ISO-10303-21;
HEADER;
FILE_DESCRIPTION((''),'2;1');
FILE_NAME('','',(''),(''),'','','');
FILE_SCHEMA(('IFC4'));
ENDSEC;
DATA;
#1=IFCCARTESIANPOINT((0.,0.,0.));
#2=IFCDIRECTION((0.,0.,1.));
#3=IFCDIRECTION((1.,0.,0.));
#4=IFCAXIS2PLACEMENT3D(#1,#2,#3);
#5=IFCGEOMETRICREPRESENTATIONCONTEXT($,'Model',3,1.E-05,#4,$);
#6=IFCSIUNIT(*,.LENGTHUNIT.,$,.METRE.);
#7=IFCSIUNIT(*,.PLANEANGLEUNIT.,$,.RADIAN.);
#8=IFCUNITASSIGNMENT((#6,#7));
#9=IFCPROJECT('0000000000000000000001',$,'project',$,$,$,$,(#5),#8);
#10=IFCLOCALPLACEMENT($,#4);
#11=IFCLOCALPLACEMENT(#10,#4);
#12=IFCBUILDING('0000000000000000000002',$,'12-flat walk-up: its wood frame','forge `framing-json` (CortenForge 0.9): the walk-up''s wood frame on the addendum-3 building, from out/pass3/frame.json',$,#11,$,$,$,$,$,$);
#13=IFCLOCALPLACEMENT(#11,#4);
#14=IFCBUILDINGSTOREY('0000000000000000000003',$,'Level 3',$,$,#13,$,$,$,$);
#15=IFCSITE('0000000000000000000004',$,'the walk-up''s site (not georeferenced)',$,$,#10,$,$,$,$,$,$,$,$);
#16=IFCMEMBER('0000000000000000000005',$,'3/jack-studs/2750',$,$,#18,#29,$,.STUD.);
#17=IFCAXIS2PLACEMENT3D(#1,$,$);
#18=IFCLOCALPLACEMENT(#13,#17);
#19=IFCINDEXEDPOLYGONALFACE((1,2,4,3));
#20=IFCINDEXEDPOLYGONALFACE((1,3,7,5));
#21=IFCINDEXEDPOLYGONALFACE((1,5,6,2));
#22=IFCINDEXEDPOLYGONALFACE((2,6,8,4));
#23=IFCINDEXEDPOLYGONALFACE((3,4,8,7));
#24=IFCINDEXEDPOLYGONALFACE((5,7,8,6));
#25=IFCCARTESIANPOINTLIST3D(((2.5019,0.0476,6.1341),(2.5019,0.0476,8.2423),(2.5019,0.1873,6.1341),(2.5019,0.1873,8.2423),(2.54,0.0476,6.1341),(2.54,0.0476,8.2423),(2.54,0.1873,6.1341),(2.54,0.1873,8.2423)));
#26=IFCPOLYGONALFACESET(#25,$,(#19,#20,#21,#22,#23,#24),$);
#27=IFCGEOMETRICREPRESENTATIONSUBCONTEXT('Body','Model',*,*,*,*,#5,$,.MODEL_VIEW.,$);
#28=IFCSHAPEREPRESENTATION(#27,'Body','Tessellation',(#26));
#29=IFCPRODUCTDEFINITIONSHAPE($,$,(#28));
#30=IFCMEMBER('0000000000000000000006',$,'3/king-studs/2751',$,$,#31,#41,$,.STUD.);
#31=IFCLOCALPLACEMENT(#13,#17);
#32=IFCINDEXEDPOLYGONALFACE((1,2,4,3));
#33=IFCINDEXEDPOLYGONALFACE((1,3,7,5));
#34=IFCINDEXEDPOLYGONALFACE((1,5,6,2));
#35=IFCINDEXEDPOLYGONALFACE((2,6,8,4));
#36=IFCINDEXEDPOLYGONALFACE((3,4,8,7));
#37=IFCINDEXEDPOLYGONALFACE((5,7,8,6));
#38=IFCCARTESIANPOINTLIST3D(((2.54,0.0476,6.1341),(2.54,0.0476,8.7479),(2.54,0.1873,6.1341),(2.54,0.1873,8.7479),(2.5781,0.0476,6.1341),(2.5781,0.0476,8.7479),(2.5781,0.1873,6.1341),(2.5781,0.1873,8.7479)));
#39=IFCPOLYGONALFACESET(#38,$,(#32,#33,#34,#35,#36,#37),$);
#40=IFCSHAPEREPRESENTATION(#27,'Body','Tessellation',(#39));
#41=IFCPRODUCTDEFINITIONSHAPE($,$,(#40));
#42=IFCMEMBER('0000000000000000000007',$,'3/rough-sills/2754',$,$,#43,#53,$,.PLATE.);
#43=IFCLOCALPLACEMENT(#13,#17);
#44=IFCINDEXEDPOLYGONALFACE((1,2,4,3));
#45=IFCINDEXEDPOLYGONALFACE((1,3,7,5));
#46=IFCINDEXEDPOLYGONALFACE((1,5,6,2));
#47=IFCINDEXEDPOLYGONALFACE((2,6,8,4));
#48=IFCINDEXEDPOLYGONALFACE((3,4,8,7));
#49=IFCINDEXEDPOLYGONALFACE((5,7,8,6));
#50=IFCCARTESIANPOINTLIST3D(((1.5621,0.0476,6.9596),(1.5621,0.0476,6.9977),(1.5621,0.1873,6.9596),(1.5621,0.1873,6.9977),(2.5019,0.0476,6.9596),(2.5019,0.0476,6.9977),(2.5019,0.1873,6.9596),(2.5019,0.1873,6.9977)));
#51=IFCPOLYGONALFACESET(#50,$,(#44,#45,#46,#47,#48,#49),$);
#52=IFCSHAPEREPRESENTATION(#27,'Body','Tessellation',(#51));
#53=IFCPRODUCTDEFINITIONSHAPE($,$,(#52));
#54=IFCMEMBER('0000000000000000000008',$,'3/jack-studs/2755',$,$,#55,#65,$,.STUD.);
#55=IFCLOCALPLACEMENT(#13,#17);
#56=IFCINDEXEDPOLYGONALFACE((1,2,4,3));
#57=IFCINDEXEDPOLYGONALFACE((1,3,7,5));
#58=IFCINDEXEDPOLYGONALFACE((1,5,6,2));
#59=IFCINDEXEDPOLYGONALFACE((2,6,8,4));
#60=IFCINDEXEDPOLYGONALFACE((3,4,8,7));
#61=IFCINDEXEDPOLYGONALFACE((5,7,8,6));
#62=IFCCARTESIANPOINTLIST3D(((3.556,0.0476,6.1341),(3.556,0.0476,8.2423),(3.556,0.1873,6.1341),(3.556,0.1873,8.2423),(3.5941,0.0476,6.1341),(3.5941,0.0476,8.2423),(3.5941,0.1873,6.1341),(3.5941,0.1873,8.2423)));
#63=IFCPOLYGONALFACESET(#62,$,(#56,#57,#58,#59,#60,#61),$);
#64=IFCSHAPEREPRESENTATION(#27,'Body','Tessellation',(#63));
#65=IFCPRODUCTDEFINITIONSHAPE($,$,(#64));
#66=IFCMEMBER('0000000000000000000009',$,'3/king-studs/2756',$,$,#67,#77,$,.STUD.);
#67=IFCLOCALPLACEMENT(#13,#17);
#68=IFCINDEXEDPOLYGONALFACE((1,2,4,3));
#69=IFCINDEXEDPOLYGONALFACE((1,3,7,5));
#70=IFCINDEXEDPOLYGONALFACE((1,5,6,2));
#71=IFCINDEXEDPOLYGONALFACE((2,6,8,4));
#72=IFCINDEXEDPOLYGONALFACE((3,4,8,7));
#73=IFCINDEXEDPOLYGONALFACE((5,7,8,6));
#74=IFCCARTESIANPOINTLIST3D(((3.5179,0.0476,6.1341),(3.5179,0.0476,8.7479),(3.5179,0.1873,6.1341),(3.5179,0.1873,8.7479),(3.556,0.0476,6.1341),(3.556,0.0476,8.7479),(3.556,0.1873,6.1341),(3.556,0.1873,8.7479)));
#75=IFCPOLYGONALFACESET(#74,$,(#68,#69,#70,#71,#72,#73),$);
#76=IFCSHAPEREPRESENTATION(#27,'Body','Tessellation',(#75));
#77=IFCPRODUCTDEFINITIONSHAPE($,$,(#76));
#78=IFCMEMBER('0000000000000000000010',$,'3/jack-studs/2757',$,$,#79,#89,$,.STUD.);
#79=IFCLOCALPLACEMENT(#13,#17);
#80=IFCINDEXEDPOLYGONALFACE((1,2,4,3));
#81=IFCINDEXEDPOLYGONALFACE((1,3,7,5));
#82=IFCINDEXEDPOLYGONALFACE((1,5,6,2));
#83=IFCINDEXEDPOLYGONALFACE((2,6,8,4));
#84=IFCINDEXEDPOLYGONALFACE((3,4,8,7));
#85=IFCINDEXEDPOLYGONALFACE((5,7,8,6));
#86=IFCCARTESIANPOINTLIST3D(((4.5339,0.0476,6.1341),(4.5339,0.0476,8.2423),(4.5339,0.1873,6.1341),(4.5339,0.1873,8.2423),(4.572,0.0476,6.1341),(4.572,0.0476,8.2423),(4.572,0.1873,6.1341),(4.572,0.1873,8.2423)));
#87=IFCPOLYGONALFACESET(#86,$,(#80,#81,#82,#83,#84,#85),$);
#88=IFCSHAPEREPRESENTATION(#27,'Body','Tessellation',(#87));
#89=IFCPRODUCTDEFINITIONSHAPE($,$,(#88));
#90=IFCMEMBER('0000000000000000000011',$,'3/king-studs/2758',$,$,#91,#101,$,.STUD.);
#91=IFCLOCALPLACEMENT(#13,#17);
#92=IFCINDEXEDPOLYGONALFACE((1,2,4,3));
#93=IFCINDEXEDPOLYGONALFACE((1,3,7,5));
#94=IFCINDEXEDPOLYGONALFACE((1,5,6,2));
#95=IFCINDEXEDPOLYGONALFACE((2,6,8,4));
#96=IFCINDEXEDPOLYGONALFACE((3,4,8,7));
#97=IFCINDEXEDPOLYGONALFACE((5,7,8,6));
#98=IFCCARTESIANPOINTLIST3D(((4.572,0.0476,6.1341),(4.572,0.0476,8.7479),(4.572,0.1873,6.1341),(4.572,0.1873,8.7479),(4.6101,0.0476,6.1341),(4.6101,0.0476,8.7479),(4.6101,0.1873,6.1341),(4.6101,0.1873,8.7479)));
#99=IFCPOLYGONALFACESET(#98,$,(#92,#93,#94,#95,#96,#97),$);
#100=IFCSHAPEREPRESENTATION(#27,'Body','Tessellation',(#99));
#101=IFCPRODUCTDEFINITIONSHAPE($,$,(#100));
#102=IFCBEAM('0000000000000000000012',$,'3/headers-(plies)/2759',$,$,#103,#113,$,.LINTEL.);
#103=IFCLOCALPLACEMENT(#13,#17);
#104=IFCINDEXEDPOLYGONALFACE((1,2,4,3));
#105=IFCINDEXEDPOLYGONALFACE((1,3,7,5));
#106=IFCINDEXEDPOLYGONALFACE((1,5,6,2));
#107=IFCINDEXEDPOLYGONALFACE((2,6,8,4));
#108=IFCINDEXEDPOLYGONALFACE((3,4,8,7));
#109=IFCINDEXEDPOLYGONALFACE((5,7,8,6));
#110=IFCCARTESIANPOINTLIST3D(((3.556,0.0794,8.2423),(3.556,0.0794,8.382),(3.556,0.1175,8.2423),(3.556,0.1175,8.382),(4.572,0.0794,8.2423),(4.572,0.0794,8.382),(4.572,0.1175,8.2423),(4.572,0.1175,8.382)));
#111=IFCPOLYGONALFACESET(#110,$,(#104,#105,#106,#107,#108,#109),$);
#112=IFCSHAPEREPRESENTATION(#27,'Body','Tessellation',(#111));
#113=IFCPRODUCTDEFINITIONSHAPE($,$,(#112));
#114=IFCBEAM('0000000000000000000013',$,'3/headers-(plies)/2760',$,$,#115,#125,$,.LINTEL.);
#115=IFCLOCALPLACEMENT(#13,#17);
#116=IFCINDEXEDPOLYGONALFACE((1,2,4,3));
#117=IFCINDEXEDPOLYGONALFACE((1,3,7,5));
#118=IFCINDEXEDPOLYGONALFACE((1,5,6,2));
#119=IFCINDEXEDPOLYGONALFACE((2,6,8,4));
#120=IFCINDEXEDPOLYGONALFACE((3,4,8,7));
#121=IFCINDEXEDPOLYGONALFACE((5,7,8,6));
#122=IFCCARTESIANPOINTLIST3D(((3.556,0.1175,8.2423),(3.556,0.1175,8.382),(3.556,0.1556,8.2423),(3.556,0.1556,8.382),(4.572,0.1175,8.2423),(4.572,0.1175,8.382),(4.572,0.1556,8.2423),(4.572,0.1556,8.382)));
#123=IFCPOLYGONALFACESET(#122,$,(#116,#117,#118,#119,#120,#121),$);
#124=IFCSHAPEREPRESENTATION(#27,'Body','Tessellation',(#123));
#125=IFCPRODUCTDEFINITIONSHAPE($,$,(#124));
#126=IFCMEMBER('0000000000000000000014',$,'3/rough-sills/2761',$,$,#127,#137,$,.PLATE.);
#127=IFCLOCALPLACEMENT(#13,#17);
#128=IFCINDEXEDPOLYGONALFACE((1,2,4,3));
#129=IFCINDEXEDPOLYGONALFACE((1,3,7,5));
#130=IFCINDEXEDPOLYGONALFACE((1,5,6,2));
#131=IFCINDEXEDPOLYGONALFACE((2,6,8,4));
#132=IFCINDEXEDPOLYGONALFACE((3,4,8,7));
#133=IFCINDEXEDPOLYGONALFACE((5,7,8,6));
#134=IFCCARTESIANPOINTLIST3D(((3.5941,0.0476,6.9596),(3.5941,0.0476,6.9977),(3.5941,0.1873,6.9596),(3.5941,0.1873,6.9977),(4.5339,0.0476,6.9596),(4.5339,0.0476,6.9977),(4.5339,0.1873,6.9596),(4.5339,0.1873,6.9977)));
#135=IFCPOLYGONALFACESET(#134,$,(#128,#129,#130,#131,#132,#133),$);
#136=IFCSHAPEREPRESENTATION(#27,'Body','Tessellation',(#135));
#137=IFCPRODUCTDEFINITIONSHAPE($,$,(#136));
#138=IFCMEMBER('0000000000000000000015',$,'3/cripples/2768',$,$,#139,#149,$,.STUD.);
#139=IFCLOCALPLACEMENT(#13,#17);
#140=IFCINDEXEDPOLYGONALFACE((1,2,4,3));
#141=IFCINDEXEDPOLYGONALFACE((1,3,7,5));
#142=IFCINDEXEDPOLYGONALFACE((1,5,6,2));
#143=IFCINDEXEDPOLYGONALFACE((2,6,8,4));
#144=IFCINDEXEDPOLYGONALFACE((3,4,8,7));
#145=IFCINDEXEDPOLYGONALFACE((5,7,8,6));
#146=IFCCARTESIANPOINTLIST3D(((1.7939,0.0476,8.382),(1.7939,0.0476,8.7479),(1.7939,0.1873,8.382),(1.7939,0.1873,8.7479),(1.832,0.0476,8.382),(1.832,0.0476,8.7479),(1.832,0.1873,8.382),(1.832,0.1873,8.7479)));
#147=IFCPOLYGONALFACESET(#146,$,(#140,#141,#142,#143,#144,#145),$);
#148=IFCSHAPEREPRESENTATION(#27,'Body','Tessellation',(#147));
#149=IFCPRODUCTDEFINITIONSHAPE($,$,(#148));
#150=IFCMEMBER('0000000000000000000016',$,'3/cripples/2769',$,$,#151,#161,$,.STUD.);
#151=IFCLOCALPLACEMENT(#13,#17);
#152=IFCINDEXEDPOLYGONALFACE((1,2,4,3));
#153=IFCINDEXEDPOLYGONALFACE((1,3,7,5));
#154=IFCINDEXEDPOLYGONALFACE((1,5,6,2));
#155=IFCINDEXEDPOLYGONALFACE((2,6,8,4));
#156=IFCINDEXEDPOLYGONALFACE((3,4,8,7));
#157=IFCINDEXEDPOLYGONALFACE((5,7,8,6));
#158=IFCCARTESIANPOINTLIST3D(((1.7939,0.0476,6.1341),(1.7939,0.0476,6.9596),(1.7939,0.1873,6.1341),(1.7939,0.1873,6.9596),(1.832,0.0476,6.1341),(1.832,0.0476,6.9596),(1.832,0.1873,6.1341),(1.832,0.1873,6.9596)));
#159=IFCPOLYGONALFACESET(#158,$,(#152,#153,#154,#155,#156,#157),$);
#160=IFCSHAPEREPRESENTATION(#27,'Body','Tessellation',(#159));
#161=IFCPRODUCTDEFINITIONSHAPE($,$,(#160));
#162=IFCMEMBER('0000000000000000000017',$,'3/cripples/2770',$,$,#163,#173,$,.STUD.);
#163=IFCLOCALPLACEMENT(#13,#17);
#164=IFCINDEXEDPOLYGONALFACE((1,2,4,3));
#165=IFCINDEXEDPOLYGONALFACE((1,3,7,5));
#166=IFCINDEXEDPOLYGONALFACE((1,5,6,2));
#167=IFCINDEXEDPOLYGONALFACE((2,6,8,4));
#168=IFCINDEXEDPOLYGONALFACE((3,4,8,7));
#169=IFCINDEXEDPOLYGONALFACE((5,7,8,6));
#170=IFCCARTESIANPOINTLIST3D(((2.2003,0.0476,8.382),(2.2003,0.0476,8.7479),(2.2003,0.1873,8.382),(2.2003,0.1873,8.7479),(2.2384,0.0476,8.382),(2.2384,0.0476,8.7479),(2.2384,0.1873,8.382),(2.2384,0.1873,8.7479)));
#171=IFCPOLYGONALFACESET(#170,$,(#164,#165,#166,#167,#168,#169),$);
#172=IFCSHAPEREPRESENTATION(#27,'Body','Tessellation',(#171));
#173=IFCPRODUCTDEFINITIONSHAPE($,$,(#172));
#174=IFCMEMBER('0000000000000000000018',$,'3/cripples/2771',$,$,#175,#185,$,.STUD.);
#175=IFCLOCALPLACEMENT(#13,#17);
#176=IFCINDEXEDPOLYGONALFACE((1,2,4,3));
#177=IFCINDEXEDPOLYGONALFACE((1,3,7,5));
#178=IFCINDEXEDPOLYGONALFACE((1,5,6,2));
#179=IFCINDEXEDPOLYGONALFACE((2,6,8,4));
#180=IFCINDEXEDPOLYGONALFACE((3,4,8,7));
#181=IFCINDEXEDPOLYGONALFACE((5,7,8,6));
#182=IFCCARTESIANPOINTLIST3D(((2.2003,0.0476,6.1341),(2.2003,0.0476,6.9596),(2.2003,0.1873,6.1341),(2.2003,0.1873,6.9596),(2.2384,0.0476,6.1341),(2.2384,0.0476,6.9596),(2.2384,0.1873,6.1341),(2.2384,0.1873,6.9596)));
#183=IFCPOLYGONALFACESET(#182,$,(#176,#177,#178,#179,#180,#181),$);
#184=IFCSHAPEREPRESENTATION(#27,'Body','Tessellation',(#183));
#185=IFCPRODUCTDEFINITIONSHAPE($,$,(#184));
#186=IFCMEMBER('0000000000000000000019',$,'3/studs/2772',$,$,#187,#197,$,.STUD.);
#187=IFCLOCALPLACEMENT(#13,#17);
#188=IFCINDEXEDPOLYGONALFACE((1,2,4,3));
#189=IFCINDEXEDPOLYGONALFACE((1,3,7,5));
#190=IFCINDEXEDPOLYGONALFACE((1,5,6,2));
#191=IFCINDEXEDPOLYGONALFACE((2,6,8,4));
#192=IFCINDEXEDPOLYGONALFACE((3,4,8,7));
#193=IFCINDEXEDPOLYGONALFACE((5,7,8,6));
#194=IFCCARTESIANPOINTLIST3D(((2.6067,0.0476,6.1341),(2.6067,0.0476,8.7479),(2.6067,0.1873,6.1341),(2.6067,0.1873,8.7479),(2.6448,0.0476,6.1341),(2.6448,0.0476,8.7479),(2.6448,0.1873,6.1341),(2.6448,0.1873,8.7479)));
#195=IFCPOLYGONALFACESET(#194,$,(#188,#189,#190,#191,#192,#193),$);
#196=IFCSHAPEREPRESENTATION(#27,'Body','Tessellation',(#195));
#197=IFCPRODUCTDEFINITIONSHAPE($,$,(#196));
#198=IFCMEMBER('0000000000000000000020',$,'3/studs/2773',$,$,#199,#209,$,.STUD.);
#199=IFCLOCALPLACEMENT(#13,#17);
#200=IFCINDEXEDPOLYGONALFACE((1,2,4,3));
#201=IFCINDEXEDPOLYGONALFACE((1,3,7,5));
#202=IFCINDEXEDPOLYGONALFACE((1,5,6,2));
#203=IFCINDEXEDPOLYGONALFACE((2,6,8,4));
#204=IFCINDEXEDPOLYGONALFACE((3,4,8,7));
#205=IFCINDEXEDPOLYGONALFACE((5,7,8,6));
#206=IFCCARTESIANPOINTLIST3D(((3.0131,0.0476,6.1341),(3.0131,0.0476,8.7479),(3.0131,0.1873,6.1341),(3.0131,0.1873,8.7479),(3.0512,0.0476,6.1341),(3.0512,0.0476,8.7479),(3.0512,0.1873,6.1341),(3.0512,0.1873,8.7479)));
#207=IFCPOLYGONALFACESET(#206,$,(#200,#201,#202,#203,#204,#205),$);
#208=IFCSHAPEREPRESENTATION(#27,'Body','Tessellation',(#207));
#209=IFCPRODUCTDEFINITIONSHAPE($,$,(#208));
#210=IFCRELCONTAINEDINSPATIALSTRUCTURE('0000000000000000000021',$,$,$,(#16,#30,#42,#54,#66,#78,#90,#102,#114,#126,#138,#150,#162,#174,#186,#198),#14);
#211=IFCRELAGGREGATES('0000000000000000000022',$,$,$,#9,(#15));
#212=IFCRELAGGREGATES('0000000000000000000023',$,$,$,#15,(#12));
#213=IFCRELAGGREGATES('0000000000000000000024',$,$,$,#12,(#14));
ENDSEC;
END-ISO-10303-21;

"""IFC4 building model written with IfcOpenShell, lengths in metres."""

from ifc_helpers import new_model, si_unit, frame, frame_2d, origin, origin_with_axes, place, context, subcontext, project, spatial, rectangle, extrude, element, save


model = new_model("IFC4")

# Units and contexts
model_context = context("Model", 3, precision=1e-05, world=origin_with_axes())
body_context = subcontext(model_context, "Body", "Model", "MODEL_VIEW")
ifc_project = project(units=[si_unit("LENGTHUNIT", "METRE"), si_unit("PLANEANGLEUNIT", "RADIAN")], contexts=[model_context])

# Site, building, storey
site_placement = place(None, origin_with_axes())
site = spatial("IfcSite", under=ifc_project, at=site_placement, Name="the walk-up's site (not georeferenced)")
building_placement = place(site_placement, origin_with_axes())
building = spatial("IfcBuilding", under=site, at=building_placement, Name="12-flat walk-up: its wood frame", Description="forge `framing-json` (CortenForge 0.9): the walk-up's wood frame on the addendum-3 building, from out/pass3/frame.json")
storey_placement = place(building_placement, origin_with_axes())
storey = spatial("IfcBuildingStorey", under=building, at=storey_placement, Name="Level 3")

# Members
member_1_placement = place(storey_placement, frame((2.5019, 0.0476, 6.1341), z_axis=(0.0, 0.0, 1.0), x_axis=(1.0, 0.0, 0.0)))
element("IfcMember", 1, at=member_1_placement, inside=storey, Name="3/jack-studs/2750", PredefinedType="STUD", context=body_context, shape_type="SweptSolid", body=[
    extrude(rectangle(XDim=0.0381, YDim=0.1397, at=frame_2d((0.0191, 0.0698))), origin(), (0.0, 0.0, 1.0), 2.1082),
])
member_2_placement = place(storey_placement, frame((2.54, 0.0476, 6.1341), z_axis=(0.0, 0.0, 1.0), x_axis=(1.0, 0.0, 0.0)))
element("IfcMember", 2, at=member_2_placement, inside=storey, Name="3/king-studs/2751", PredefinedType="STUD", context=body_context, shape_type="SweptSolid", body=[
    extrude(rectangle(XDim=0.0381, YDim=0.1397, at=frame_2d((0.0191, 0.0698))), origin(), (0.0, 0.0, 1.0), 2.6138),
])
member_3_placement = place(storey_placement, frame((1.5621, 0.0476, 6.9596), z_axis=(0.0, 0.0, 1.0), x_axis=(1.0, 0.0, 0.0)))
element("IfcMember", 3, at=member_3_placement, inside=storey, Name="3/rough-sills/2754", PredefinedType="PLATE", context=body_context, shape_type="SweptSolid", body=[
    extrude(rectangle(XDim=0.9398, YDim=0.1397, at=frame_2d((0.4699, 0.0698))), origin(), (0.0, 0.0, 1.0), 0.0381),
])
member_4_placement = place(storey_placement, frame((3.556, 0.0476, 6.1341), z_axis=(0.0, 0.0, 1.0), x_axis=(1.0, 0.0, 0.0)))
element("IfcMember", 4, at=member_4_placement, inside=storey, Name="3/jack-studs/2755", PredefinedType="STUD", context=body_context, shape_type="SweptSolid", body=[
    extrude(rectangle(XDim=0.0381, YDim=0.1397, at=frame_2d((0.0191, 0.0698))), origin(), (0.0, 0.0, 1.0), 2.1082),
])
member_5_placement = place(storey_placement, frame((3.5179, 0.0476, 6.1341), z_axis=(0.0, 0.0, 1.0), x_axis=(1.0, 0.0, 0.0)))
element("IfcMember", 5, at=member_5_placement, inside=storey, Name="3/king-studs/2756", PredefinedType="STUD", context=body_context, shape_type="SweptSolid", body=[
    extrude(rectangle(XDim=0.0381, YDim=0.1397, at=frame_2d((0.0191, 0.0698))), origin(), (0.0, 0.0, 1.0), 2.6138),
])
member_6_placement = place(storey_placement, frame((4.5339, 0.0476, 6.1341), z_axis=(0.0, 0.0, 1.0), x_axis=(1.0, 0.0, 0.0)))
element("IfcMember", 6, at=member_6_placement, inside=storey, Name="3/jack-studs/2757", PredefinedType="STUD", context=body_context, shape_type="SweptSolid", body=[
    extrude(rectangle(XDim=0.0381, YDim=0.1397, at=frame_2d((0.0191, 0.0698))), origin(), (0.0, 0.0, 1.0), 2.1082),
])
member_7_placement = place(storey_placement, frame((4.572, 0.0476, 6.1341), z_axis=(0.0, 0.0, 1.0), x_axis=(1.0, 0.0, 0.0)))
element("IfcMember", 7, at=member_7_placement, inside=storey, Name="3/king-studs/2758", PredefinedType="STUD", context=body_context, shape_type="SweptSolid", body=[
    extrude(rectangle(XDim=0.0381, YDim=0.1397, at=frame_2d((0.0191, 0.0698))), origin(), (0.0, 0.0, 1.0), 2.6138),
])

# Beams
for number, where, z_axis, x_axis, name in (
    (8, (3.556, 0.0794, 8.2423), (0.0, 0.0, 1.0), (1.0, 0.0, 0.0), "3/headers-(plies)/2759"),
    (9, (3.556, 0.1175, 8.2423), (0.0, 0.0, 1.0), (1.0, 0.0, 0.0), "3/headers-(plies)/2760"),
):
    element("IfcBeam", number, at=place(storey_placement, frame(where, z_axis=z_axis, x_axis=x_axis)), inside=storey, Name=name, PredefinedType="LINTEL", context=body_context, shape_type="SweptSolid", body=[
        extrude(rectangle(XDim=1.016, YDim=0.0381, at=frame_2d((0.508, 0.019))), origin(), (0.0, 0.0, 1.0), 0.1397),
    ])

# Members
member_8_placement = place(storey_placement, frame((3.5941, 0.0476, 6.9596), z_axis=(0.0, 0.0, 1.0), x_axis=(1.0, 0.0, 0.0)))
element("IfcMember", 10, at=member_8_placement, inside=storey, Name="3/rough-sills/2761", PredefinedType="PLATE", context=body_context, shape_type="SweptSolid", body=[
    extrude(rectangle(XDim=0.9398, YDim=0.1397, at=frame_2d((0.4699, 0.0698))), origin(), (0.0, 0.0, 1.0), 0.0381),
])
member_9_placement = place(storey_placement, frame((1.7939, 0.0476, 8.382), z_axis=(0.0, 0.0, 1.0), x_axis=(1.0, 0.0, 0.0)))
element("IfcMember", 11, at=member_9_placement, inside=storey, Name="3/cripples/2768", PredefinedType="STUD", context=body_context, shape_type="SweptSolid", body=[
    extrude(rectangle(XDim=0.0381, YDim=0.1397, at=frame_2d((0.019, 0.0698))), origin(), (0.0, 0.0, 1.0), 0.3659),
])
member_10_placement = place(storey_placement, frame((1.7939, 0.0476, 6.1341), z_axis=(0.0, 0.0, 1.0), x_axis=(1.0, 0.0, 0.0)))
element("IfcMember", 12, at=member_10_placement, inside=storey, Name="3/cripples/2769", PredefinedType="STUD", context=body_context, shape_type="SweptSolid", body=[
    extrude(rectangle(XDim=0.0381, YDim=0.1397, at=frame_2d((0.019, 0.0698))), origin(), (0.0, 0.0, 1.0), 0.8255),
])
member_11_placement = place(storey_placement, frame((2.2003, 0.0476, 8.382), z_axis=(0.0, 0.0, 1.0), x_axis=(1.0, 0.0, 0.0)))
element("IfcMember", 13, at=member_11_placement, inside=storey, Name="3/cripples/2770", PredefinedType="STUD", context=body_context, shape_type="SweptSolid", body=[
    extrude(rectangle(XDim=0.0381, YDim=0.1397, at=frame_2d((0.0191, 0.0698))), origin(), (0.0, 0.0, 1.0), 0.3659),
])
member_12_placement = place(storey_placement, frame((2.2003, 0.0476, 6.1341), z_axis=(0.0, 0.0, 1.0), x_axis=(1.0, 0.0, 0.0)))
element("IfcMember", 14, at=member_12_placement, inside=storey, Name="3/cripples/2771", PredefinedType="STUD", context=body_context, shape_type="SweptSolid", body=[
    extrude(rectangle(XDim=0.0381, YDim=0.1397, at=frame_2d((0.0191, 0.0698))), origin(), (0.0, 0.0, 1.0), 0.8255),
])
for number, where, z_axis, x_axis, name in (
    (15, (2.6067, 0.0476, 6.1341), (0.0, 0.0, 1.0), (1.0, 0.0, 0.0), "3/studs/2772"),
    (16, (3.0131, 0.0476, 6.1341), (0.0, 0.0, 1.0), (1.0, 0.0, 0.0), "3/studs/2773"),
):
    element("IfcMember", number, at=place(storey_placement, frame(where, z_axis=z_axis, x_axis=x_axis)), inside=storey, Name=name, PredefinedType="STUD", context=body_context, shape_type="SweptSolid", body=[
        extrude(rectangle(XDim=0.0381, YDim=0.1397, at=frame_2d((0.0191, 0.0698))), origin(), (0.0, 0.0, 1.0), 2.6138),
    ])

save(model, "model.ifc")
